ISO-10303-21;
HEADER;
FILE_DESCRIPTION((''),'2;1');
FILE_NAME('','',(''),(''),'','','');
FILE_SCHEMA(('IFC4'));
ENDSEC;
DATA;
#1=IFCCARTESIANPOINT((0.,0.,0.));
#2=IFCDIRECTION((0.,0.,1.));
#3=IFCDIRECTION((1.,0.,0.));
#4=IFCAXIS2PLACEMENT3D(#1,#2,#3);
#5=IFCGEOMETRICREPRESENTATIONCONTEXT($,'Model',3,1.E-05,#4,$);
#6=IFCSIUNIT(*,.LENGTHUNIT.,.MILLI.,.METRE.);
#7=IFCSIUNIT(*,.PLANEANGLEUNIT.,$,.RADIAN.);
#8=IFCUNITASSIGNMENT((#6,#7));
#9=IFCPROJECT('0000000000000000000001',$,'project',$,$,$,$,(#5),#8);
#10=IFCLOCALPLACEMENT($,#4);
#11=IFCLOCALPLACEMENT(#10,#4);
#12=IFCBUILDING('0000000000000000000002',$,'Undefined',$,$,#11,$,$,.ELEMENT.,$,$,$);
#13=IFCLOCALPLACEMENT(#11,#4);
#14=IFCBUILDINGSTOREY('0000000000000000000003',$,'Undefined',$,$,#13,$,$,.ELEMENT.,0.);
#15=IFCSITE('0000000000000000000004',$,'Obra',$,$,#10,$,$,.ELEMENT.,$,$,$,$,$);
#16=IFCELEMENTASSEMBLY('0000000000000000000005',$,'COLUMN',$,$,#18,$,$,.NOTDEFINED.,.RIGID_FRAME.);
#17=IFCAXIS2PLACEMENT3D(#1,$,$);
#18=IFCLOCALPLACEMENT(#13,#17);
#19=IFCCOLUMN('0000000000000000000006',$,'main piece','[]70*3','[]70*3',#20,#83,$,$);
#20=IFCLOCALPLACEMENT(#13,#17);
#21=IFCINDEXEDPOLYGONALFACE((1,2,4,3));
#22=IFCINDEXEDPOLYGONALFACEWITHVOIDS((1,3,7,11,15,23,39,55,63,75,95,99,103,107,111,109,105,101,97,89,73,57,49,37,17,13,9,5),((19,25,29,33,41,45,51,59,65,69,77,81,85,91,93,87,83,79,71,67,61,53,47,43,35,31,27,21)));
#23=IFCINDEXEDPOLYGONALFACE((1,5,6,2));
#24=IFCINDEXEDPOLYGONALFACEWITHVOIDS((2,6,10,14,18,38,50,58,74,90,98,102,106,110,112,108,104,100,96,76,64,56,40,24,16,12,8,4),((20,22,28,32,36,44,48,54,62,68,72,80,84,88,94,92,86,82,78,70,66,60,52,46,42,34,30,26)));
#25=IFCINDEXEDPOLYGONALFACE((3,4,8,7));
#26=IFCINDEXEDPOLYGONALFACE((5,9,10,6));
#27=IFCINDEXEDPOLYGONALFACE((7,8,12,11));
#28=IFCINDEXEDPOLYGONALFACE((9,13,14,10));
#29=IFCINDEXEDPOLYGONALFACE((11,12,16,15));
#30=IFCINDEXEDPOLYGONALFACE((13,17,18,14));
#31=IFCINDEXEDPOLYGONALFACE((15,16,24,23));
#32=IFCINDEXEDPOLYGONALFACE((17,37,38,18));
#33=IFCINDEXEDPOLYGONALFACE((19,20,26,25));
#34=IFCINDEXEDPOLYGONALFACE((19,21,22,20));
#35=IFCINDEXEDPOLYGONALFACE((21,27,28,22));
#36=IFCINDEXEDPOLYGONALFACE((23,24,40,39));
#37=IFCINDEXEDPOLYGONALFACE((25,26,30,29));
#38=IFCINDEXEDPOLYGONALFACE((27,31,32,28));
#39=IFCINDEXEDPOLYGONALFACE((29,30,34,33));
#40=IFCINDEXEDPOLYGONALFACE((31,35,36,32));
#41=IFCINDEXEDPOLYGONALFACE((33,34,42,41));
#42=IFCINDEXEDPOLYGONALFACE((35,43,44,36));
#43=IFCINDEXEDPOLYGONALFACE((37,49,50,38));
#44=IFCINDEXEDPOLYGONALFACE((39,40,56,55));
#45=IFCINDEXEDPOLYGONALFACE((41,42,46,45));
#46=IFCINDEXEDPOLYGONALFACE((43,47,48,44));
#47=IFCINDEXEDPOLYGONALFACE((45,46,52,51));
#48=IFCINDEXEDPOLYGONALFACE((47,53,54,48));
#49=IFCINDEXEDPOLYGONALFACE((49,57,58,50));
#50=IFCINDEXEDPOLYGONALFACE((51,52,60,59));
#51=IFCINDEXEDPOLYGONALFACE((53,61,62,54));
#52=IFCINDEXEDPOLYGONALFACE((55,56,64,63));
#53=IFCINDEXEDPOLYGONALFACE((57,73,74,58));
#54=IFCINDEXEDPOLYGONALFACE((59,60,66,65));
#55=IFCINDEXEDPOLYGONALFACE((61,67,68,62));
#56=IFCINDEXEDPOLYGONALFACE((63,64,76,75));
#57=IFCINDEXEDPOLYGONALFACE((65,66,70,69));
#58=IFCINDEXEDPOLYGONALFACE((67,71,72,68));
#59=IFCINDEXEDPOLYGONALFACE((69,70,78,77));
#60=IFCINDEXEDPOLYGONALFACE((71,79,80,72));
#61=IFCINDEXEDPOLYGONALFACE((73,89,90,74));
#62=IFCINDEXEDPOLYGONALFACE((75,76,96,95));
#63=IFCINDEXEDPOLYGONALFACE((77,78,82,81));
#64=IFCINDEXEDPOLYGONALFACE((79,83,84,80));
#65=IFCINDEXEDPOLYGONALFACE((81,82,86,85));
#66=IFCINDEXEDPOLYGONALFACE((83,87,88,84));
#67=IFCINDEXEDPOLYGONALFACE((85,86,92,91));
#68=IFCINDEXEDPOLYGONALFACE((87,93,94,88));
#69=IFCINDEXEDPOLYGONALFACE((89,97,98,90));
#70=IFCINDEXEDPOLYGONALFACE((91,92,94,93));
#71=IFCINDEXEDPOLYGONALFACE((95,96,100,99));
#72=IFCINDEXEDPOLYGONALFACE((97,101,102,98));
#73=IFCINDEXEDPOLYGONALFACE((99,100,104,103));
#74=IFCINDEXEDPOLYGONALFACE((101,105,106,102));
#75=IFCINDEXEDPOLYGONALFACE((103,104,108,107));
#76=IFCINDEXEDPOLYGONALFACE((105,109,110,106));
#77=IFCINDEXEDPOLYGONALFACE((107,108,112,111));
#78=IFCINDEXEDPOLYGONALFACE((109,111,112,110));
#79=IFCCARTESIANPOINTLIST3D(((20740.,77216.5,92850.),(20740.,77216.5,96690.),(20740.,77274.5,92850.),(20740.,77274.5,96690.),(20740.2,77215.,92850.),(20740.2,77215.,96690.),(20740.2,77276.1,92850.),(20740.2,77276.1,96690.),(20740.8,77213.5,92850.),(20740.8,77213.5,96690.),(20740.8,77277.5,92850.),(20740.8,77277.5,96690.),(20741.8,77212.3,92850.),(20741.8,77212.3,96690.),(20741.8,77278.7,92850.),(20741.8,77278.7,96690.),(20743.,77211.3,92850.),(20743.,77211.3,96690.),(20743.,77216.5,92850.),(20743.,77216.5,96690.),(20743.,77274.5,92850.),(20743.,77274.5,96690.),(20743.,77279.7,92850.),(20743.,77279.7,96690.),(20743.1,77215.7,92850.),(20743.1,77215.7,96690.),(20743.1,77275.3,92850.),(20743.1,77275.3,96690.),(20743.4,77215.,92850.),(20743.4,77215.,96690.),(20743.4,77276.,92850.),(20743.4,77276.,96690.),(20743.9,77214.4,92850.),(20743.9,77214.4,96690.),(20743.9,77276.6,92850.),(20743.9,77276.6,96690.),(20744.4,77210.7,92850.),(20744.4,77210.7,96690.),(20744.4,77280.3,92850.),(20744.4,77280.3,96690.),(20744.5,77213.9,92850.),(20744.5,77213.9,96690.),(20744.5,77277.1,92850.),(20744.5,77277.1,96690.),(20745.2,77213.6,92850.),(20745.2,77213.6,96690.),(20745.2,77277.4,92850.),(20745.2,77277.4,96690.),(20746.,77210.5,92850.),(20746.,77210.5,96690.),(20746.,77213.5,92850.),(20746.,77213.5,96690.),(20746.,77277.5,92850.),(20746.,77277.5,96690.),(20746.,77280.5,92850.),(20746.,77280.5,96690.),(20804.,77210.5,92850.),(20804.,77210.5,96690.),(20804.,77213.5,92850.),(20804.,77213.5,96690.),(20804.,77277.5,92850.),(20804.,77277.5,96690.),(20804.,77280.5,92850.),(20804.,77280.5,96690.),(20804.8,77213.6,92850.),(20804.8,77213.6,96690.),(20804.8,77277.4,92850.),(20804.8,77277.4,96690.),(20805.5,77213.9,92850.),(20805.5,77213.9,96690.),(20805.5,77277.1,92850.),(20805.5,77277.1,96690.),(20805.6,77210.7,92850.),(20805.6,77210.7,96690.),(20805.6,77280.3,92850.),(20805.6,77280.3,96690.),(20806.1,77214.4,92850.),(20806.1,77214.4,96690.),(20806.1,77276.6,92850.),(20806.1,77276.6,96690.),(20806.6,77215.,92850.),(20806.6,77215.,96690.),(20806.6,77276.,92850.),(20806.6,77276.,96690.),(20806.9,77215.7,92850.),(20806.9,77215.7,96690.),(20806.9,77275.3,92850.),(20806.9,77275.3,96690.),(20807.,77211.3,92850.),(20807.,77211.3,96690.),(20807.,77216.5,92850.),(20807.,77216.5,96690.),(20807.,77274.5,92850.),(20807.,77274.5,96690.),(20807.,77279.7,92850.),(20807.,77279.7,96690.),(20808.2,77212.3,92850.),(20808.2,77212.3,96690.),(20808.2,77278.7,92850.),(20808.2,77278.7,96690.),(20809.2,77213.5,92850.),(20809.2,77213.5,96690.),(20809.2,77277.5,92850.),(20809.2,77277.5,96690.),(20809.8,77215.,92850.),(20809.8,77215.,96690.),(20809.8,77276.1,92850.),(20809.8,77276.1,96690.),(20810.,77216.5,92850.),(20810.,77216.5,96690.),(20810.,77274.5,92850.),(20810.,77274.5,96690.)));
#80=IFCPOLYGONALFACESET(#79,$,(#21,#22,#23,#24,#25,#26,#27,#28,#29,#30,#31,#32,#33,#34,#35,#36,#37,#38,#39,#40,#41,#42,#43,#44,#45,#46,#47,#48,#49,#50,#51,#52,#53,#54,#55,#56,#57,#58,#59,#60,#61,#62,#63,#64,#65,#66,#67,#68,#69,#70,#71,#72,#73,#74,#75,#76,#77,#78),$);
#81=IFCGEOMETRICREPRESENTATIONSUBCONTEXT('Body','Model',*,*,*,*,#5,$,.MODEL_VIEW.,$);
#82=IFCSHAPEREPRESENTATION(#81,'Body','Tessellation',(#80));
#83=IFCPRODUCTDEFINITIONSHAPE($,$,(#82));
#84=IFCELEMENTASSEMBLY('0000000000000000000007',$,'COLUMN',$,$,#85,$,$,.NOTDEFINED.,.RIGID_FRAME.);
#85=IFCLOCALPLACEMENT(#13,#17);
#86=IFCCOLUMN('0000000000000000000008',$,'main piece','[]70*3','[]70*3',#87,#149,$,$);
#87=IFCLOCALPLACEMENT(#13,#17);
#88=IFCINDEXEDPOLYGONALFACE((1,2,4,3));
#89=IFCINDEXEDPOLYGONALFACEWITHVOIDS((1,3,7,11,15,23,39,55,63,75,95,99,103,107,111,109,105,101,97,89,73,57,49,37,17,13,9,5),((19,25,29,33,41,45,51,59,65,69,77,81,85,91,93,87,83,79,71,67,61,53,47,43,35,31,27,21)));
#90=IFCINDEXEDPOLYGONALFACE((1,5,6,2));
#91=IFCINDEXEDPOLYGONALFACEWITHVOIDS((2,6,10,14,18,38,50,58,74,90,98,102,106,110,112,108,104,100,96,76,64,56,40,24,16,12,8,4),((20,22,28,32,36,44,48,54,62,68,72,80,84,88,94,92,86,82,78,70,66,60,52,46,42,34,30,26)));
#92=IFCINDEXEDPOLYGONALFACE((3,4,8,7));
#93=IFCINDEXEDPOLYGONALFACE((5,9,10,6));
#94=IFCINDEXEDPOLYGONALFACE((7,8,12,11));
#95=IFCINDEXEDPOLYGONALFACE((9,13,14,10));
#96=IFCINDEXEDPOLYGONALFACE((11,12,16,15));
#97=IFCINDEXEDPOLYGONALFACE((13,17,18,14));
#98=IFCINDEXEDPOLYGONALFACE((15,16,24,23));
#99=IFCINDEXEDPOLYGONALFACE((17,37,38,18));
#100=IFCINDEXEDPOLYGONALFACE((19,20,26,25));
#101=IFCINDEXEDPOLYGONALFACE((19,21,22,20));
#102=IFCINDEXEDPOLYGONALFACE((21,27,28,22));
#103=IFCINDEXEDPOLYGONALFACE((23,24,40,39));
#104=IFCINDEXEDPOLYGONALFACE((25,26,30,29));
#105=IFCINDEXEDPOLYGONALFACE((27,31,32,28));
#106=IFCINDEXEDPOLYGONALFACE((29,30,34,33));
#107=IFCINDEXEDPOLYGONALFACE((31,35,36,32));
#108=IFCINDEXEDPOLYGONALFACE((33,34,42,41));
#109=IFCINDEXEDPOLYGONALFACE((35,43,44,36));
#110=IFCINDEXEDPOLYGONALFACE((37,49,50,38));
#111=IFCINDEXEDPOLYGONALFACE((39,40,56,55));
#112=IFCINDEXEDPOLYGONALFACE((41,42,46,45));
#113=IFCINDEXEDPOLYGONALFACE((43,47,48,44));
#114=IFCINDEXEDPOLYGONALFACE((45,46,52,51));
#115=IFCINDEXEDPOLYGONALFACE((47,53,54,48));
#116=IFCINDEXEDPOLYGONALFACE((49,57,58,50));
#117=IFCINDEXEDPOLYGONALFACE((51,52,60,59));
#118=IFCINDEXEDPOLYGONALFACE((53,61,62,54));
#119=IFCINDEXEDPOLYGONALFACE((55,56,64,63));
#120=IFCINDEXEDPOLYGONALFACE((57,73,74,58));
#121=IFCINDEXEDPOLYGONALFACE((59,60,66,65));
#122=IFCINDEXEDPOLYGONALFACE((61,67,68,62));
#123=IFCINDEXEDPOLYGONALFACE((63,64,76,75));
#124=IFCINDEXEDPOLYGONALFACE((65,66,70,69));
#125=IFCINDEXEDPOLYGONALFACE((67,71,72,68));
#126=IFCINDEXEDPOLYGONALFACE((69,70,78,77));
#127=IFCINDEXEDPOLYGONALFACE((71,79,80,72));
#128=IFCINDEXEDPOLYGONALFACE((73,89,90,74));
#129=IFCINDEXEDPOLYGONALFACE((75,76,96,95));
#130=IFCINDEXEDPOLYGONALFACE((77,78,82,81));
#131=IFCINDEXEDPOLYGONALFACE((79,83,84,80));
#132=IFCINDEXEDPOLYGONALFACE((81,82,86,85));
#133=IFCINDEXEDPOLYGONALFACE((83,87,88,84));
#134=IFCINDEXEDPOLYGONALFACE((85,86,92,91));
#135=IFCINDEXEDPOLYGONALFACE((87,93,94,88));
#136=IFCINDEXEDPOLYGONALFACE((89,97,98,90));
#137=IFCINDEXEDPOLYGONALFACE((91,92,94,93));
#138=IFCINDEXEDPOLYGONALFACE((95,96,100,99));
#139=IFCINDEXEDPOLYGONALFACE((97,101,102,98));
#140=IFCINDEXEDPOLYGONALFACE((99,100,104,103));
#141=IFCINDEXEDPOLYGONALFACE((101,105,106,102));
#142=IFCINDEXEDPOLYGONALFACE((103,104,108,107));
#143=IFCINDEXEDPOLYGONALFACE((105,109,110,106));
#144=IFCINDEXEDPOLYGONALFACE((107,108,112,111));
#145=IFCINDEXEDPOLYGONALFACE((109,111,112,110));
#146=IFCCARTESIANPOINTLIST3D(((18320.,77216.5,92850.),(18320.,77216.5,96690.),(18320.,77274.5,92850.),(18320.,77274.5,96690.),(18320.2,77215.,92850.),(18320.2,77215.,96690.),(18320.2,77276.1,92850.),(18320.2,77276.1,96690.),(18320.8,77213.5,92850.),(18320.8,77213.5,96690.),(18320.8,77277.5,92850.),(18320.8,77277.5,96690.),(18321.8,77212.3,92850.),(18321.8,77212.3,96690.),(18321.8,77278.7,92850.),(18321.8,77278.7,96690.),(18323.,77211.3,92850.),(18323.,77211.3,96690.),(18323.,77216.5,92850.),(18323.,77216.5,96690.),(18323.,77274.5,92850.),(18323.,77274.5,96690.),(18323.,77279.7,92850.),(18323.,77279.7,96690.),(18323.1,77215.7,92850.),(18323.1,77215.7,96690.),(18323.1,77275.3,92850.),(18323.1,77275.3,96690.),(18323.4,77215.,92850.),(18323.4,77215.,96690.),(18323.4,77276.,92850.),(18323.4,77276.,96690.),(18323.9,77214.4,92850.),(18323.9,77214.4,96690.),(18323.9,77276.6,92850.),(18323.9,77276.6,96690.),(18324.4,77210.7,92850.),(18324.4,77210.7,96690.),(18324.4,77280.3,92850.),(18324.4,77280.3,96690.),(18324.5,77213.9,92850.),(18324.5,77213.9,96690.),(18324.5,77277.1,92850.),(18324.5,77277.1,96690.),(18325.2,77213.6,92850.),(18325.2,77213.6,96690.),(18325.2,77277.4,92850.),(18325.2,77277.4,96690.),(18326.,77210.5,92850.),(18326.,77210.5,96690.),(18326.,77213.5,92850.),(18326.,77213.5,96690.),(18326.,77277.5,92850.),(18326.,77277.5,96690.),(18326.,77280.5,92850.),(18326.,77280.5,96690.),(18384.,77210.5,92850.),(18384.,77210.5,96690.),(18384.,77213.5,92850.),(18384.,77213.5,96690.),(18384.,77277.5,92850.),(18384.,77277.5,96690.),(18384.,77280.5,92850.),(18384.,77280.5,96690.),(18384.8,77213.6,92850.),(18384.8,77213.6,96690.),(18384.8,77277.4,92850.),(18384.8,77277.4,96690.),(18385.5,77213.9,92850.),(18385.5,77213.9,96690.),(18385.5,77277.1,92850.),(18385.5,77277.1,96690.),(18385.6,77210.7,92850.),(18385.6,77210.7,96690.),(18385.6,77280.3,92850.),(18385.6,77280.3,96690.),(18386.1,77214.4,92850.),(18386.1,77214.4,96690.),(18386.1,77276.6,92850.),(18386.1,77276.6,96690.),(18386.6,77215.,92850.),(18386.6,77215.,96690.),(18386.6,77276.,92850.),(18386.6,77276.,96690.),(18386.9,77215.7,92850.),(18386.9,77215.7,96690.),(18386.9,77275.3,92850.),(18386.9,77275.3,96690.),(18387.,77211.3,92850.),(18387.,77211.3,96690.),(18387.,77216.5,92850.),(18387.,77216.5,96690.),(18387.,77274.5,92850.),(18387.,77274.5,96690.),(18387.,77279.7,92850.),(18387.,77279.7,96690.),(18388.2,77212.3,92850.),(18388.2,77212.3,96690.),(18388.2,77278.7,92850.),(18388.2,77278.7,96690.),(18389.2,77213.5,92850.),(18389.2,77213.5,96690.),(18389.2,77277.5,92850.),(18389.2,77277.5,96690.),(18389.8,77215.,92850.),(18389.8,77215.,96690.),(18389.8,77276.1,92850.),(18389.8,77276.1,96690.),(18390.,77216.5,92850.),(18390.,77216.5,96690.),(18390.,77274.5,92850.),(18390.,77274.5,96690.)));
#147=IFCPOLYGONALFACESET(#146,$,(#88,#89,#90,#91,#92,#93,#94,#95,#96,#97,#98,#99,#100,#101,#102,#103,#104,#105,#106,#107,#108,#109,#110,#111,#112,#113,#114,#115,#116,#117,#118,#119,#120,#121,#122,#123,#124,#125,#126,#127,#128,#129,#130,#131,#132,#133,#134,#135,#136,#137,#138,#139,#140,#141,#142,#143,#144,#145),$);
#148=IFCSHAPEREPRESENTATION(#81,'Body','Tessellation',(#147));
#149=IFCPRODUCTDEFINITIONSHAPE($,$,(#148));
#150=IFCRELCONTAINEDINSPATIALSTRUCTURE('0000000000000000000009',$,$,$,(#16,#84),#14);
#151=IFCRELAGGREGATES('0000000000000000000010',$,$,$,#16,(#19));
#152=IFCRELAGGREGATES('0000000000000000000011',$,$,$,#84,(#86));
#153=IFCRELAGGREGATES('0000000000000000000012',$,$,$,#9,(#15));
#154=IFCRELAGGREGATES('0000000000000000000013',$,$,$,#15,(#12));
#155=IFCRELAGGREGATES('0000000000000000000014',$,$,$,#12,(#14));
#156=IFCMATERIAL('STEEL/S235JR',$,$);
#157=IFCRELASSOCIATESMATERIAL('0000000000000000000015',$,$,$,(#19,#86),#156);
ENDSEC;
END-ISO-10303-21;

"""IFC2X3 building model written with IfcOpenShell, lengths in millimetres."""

from ifc_helpers import new_model, si_unit, frame, origin_with_axes, origin_2d_with_axis, place, context, subcontext, project, spatial, hollow_rectangle, extrude, material, element, aggregate, save


model = new_model("IFC2X3")

# Units and contexts
model_context = context("Model", 3, precision=1e-05, world=origin_with_axes())
body_context = subcontext(model_context, "Body", "Model", "MODEL_VIEW")
ifc_project = project(units=[si_unit("LENGTHUNIT", "METRE", prefix="MILLI"), si_unit("PLANEANGLEUNIT", "RADIAN")], contexts=[model_context])

# Site, building, storey
site_placement = place(None, origin_with_axes())
site = spatial("IfcSite", under=ifc_project, at=site_placement, Name="Obra", CompositionType="ELEMENT")
building_placement = place(site_placement, origin_with_axes())
building = spatial("IfcBuilding", under=site, at=building_placement, Name="Undefined", CompositionType="ELEMENT")
storey_placement = place(building_placement, origin_with_axes())
storey = spatial("IfcBuildingStorey", under=building, at=storey_placement, Name="Undefined", CompositionType="ELEMENT", Elevation=0.0)

# Element assemblies, columns
assembly_1_placement = place(storey_placement, origin_with_axes())
assembly_1 = element("IfcElementAssembly", 1, at=assembly_1_placement, inside=storey, Name="COLUMN", AssemblyPlace="NOTDEFINED", PredefinedType="RIGID_FRAME")
ifc_material = material(Name="STEEL/S235JR")
column_1_placement = place(assembly_1_placement, frame((20775.0, 77245.5, 92850.0), z_axis=(0.0, 0.0, 1.0), x_axis=(0.0, 1.0, 0.0)))
column_1 = element("IfcColumn", 2, at=column_1_placement, material=ifc_material, Name="main piece", Description="[]70*3", ObjectType="[]70*3", context=body_context, shape_type="SweptSolid", body=[
    extrude(hollow_rectangle(XDim=70.0, YDim=70.0, WallThickness=3.0, InnerFilletRadius=3.0, OuterFilletRadius=6.0, at=origin_2d_with_axis()), frame((0.0, 0.0, 3840.0), z_axis=(0.0, 0.0, -1.0), x_axis=(0.0, 1.0, 0.0)), (0.0, 0.0, 1.0), 3840.0),
])
aggregate(assembly_1, [column_1])
assembly_2_placement = place(storey_placement, origin_with_axes())
assembly_2 = element("IfcElementAssembly", 3, at=assembly_2_placement, inside=storey, Name="COLUMN", AssemblyPlace="NOTDEFINED", PredefinedType="RIGID_FRAME")
column_2_placement = place(assembly_2_placement, frame((18355.0, 77245.5, 92850.0), z_axis=(0.0, 0.0, 1.0), x_axis=(0.0, 1.0, 0.0)))
column_2 = element("IfcColumn", 4, at=column_2_placement, material=ifc_material, Name="main piece", Description="[]70*3", ObjectType="[]70*3", context=body_context, shape_type="SweptSolid", body=[
    extrude(hollow_rectangle(XDim=70.0, YDim=70.0, WallThickness=3.0, InnerFilletRadius=3.0, OuterFilletRadius=6.0, at=origin_2d_with_axis()), frame((0.0, 0.0, 3840.0), z_axis=(0.0, 0.0, -1.0), x_axis=(0.0, 1.0, 0.0)), (0.0, 0.0, 1.0), 3840.0),
])
aggregate(assembly_2, [column_2])

save(model, "model.ifc")
